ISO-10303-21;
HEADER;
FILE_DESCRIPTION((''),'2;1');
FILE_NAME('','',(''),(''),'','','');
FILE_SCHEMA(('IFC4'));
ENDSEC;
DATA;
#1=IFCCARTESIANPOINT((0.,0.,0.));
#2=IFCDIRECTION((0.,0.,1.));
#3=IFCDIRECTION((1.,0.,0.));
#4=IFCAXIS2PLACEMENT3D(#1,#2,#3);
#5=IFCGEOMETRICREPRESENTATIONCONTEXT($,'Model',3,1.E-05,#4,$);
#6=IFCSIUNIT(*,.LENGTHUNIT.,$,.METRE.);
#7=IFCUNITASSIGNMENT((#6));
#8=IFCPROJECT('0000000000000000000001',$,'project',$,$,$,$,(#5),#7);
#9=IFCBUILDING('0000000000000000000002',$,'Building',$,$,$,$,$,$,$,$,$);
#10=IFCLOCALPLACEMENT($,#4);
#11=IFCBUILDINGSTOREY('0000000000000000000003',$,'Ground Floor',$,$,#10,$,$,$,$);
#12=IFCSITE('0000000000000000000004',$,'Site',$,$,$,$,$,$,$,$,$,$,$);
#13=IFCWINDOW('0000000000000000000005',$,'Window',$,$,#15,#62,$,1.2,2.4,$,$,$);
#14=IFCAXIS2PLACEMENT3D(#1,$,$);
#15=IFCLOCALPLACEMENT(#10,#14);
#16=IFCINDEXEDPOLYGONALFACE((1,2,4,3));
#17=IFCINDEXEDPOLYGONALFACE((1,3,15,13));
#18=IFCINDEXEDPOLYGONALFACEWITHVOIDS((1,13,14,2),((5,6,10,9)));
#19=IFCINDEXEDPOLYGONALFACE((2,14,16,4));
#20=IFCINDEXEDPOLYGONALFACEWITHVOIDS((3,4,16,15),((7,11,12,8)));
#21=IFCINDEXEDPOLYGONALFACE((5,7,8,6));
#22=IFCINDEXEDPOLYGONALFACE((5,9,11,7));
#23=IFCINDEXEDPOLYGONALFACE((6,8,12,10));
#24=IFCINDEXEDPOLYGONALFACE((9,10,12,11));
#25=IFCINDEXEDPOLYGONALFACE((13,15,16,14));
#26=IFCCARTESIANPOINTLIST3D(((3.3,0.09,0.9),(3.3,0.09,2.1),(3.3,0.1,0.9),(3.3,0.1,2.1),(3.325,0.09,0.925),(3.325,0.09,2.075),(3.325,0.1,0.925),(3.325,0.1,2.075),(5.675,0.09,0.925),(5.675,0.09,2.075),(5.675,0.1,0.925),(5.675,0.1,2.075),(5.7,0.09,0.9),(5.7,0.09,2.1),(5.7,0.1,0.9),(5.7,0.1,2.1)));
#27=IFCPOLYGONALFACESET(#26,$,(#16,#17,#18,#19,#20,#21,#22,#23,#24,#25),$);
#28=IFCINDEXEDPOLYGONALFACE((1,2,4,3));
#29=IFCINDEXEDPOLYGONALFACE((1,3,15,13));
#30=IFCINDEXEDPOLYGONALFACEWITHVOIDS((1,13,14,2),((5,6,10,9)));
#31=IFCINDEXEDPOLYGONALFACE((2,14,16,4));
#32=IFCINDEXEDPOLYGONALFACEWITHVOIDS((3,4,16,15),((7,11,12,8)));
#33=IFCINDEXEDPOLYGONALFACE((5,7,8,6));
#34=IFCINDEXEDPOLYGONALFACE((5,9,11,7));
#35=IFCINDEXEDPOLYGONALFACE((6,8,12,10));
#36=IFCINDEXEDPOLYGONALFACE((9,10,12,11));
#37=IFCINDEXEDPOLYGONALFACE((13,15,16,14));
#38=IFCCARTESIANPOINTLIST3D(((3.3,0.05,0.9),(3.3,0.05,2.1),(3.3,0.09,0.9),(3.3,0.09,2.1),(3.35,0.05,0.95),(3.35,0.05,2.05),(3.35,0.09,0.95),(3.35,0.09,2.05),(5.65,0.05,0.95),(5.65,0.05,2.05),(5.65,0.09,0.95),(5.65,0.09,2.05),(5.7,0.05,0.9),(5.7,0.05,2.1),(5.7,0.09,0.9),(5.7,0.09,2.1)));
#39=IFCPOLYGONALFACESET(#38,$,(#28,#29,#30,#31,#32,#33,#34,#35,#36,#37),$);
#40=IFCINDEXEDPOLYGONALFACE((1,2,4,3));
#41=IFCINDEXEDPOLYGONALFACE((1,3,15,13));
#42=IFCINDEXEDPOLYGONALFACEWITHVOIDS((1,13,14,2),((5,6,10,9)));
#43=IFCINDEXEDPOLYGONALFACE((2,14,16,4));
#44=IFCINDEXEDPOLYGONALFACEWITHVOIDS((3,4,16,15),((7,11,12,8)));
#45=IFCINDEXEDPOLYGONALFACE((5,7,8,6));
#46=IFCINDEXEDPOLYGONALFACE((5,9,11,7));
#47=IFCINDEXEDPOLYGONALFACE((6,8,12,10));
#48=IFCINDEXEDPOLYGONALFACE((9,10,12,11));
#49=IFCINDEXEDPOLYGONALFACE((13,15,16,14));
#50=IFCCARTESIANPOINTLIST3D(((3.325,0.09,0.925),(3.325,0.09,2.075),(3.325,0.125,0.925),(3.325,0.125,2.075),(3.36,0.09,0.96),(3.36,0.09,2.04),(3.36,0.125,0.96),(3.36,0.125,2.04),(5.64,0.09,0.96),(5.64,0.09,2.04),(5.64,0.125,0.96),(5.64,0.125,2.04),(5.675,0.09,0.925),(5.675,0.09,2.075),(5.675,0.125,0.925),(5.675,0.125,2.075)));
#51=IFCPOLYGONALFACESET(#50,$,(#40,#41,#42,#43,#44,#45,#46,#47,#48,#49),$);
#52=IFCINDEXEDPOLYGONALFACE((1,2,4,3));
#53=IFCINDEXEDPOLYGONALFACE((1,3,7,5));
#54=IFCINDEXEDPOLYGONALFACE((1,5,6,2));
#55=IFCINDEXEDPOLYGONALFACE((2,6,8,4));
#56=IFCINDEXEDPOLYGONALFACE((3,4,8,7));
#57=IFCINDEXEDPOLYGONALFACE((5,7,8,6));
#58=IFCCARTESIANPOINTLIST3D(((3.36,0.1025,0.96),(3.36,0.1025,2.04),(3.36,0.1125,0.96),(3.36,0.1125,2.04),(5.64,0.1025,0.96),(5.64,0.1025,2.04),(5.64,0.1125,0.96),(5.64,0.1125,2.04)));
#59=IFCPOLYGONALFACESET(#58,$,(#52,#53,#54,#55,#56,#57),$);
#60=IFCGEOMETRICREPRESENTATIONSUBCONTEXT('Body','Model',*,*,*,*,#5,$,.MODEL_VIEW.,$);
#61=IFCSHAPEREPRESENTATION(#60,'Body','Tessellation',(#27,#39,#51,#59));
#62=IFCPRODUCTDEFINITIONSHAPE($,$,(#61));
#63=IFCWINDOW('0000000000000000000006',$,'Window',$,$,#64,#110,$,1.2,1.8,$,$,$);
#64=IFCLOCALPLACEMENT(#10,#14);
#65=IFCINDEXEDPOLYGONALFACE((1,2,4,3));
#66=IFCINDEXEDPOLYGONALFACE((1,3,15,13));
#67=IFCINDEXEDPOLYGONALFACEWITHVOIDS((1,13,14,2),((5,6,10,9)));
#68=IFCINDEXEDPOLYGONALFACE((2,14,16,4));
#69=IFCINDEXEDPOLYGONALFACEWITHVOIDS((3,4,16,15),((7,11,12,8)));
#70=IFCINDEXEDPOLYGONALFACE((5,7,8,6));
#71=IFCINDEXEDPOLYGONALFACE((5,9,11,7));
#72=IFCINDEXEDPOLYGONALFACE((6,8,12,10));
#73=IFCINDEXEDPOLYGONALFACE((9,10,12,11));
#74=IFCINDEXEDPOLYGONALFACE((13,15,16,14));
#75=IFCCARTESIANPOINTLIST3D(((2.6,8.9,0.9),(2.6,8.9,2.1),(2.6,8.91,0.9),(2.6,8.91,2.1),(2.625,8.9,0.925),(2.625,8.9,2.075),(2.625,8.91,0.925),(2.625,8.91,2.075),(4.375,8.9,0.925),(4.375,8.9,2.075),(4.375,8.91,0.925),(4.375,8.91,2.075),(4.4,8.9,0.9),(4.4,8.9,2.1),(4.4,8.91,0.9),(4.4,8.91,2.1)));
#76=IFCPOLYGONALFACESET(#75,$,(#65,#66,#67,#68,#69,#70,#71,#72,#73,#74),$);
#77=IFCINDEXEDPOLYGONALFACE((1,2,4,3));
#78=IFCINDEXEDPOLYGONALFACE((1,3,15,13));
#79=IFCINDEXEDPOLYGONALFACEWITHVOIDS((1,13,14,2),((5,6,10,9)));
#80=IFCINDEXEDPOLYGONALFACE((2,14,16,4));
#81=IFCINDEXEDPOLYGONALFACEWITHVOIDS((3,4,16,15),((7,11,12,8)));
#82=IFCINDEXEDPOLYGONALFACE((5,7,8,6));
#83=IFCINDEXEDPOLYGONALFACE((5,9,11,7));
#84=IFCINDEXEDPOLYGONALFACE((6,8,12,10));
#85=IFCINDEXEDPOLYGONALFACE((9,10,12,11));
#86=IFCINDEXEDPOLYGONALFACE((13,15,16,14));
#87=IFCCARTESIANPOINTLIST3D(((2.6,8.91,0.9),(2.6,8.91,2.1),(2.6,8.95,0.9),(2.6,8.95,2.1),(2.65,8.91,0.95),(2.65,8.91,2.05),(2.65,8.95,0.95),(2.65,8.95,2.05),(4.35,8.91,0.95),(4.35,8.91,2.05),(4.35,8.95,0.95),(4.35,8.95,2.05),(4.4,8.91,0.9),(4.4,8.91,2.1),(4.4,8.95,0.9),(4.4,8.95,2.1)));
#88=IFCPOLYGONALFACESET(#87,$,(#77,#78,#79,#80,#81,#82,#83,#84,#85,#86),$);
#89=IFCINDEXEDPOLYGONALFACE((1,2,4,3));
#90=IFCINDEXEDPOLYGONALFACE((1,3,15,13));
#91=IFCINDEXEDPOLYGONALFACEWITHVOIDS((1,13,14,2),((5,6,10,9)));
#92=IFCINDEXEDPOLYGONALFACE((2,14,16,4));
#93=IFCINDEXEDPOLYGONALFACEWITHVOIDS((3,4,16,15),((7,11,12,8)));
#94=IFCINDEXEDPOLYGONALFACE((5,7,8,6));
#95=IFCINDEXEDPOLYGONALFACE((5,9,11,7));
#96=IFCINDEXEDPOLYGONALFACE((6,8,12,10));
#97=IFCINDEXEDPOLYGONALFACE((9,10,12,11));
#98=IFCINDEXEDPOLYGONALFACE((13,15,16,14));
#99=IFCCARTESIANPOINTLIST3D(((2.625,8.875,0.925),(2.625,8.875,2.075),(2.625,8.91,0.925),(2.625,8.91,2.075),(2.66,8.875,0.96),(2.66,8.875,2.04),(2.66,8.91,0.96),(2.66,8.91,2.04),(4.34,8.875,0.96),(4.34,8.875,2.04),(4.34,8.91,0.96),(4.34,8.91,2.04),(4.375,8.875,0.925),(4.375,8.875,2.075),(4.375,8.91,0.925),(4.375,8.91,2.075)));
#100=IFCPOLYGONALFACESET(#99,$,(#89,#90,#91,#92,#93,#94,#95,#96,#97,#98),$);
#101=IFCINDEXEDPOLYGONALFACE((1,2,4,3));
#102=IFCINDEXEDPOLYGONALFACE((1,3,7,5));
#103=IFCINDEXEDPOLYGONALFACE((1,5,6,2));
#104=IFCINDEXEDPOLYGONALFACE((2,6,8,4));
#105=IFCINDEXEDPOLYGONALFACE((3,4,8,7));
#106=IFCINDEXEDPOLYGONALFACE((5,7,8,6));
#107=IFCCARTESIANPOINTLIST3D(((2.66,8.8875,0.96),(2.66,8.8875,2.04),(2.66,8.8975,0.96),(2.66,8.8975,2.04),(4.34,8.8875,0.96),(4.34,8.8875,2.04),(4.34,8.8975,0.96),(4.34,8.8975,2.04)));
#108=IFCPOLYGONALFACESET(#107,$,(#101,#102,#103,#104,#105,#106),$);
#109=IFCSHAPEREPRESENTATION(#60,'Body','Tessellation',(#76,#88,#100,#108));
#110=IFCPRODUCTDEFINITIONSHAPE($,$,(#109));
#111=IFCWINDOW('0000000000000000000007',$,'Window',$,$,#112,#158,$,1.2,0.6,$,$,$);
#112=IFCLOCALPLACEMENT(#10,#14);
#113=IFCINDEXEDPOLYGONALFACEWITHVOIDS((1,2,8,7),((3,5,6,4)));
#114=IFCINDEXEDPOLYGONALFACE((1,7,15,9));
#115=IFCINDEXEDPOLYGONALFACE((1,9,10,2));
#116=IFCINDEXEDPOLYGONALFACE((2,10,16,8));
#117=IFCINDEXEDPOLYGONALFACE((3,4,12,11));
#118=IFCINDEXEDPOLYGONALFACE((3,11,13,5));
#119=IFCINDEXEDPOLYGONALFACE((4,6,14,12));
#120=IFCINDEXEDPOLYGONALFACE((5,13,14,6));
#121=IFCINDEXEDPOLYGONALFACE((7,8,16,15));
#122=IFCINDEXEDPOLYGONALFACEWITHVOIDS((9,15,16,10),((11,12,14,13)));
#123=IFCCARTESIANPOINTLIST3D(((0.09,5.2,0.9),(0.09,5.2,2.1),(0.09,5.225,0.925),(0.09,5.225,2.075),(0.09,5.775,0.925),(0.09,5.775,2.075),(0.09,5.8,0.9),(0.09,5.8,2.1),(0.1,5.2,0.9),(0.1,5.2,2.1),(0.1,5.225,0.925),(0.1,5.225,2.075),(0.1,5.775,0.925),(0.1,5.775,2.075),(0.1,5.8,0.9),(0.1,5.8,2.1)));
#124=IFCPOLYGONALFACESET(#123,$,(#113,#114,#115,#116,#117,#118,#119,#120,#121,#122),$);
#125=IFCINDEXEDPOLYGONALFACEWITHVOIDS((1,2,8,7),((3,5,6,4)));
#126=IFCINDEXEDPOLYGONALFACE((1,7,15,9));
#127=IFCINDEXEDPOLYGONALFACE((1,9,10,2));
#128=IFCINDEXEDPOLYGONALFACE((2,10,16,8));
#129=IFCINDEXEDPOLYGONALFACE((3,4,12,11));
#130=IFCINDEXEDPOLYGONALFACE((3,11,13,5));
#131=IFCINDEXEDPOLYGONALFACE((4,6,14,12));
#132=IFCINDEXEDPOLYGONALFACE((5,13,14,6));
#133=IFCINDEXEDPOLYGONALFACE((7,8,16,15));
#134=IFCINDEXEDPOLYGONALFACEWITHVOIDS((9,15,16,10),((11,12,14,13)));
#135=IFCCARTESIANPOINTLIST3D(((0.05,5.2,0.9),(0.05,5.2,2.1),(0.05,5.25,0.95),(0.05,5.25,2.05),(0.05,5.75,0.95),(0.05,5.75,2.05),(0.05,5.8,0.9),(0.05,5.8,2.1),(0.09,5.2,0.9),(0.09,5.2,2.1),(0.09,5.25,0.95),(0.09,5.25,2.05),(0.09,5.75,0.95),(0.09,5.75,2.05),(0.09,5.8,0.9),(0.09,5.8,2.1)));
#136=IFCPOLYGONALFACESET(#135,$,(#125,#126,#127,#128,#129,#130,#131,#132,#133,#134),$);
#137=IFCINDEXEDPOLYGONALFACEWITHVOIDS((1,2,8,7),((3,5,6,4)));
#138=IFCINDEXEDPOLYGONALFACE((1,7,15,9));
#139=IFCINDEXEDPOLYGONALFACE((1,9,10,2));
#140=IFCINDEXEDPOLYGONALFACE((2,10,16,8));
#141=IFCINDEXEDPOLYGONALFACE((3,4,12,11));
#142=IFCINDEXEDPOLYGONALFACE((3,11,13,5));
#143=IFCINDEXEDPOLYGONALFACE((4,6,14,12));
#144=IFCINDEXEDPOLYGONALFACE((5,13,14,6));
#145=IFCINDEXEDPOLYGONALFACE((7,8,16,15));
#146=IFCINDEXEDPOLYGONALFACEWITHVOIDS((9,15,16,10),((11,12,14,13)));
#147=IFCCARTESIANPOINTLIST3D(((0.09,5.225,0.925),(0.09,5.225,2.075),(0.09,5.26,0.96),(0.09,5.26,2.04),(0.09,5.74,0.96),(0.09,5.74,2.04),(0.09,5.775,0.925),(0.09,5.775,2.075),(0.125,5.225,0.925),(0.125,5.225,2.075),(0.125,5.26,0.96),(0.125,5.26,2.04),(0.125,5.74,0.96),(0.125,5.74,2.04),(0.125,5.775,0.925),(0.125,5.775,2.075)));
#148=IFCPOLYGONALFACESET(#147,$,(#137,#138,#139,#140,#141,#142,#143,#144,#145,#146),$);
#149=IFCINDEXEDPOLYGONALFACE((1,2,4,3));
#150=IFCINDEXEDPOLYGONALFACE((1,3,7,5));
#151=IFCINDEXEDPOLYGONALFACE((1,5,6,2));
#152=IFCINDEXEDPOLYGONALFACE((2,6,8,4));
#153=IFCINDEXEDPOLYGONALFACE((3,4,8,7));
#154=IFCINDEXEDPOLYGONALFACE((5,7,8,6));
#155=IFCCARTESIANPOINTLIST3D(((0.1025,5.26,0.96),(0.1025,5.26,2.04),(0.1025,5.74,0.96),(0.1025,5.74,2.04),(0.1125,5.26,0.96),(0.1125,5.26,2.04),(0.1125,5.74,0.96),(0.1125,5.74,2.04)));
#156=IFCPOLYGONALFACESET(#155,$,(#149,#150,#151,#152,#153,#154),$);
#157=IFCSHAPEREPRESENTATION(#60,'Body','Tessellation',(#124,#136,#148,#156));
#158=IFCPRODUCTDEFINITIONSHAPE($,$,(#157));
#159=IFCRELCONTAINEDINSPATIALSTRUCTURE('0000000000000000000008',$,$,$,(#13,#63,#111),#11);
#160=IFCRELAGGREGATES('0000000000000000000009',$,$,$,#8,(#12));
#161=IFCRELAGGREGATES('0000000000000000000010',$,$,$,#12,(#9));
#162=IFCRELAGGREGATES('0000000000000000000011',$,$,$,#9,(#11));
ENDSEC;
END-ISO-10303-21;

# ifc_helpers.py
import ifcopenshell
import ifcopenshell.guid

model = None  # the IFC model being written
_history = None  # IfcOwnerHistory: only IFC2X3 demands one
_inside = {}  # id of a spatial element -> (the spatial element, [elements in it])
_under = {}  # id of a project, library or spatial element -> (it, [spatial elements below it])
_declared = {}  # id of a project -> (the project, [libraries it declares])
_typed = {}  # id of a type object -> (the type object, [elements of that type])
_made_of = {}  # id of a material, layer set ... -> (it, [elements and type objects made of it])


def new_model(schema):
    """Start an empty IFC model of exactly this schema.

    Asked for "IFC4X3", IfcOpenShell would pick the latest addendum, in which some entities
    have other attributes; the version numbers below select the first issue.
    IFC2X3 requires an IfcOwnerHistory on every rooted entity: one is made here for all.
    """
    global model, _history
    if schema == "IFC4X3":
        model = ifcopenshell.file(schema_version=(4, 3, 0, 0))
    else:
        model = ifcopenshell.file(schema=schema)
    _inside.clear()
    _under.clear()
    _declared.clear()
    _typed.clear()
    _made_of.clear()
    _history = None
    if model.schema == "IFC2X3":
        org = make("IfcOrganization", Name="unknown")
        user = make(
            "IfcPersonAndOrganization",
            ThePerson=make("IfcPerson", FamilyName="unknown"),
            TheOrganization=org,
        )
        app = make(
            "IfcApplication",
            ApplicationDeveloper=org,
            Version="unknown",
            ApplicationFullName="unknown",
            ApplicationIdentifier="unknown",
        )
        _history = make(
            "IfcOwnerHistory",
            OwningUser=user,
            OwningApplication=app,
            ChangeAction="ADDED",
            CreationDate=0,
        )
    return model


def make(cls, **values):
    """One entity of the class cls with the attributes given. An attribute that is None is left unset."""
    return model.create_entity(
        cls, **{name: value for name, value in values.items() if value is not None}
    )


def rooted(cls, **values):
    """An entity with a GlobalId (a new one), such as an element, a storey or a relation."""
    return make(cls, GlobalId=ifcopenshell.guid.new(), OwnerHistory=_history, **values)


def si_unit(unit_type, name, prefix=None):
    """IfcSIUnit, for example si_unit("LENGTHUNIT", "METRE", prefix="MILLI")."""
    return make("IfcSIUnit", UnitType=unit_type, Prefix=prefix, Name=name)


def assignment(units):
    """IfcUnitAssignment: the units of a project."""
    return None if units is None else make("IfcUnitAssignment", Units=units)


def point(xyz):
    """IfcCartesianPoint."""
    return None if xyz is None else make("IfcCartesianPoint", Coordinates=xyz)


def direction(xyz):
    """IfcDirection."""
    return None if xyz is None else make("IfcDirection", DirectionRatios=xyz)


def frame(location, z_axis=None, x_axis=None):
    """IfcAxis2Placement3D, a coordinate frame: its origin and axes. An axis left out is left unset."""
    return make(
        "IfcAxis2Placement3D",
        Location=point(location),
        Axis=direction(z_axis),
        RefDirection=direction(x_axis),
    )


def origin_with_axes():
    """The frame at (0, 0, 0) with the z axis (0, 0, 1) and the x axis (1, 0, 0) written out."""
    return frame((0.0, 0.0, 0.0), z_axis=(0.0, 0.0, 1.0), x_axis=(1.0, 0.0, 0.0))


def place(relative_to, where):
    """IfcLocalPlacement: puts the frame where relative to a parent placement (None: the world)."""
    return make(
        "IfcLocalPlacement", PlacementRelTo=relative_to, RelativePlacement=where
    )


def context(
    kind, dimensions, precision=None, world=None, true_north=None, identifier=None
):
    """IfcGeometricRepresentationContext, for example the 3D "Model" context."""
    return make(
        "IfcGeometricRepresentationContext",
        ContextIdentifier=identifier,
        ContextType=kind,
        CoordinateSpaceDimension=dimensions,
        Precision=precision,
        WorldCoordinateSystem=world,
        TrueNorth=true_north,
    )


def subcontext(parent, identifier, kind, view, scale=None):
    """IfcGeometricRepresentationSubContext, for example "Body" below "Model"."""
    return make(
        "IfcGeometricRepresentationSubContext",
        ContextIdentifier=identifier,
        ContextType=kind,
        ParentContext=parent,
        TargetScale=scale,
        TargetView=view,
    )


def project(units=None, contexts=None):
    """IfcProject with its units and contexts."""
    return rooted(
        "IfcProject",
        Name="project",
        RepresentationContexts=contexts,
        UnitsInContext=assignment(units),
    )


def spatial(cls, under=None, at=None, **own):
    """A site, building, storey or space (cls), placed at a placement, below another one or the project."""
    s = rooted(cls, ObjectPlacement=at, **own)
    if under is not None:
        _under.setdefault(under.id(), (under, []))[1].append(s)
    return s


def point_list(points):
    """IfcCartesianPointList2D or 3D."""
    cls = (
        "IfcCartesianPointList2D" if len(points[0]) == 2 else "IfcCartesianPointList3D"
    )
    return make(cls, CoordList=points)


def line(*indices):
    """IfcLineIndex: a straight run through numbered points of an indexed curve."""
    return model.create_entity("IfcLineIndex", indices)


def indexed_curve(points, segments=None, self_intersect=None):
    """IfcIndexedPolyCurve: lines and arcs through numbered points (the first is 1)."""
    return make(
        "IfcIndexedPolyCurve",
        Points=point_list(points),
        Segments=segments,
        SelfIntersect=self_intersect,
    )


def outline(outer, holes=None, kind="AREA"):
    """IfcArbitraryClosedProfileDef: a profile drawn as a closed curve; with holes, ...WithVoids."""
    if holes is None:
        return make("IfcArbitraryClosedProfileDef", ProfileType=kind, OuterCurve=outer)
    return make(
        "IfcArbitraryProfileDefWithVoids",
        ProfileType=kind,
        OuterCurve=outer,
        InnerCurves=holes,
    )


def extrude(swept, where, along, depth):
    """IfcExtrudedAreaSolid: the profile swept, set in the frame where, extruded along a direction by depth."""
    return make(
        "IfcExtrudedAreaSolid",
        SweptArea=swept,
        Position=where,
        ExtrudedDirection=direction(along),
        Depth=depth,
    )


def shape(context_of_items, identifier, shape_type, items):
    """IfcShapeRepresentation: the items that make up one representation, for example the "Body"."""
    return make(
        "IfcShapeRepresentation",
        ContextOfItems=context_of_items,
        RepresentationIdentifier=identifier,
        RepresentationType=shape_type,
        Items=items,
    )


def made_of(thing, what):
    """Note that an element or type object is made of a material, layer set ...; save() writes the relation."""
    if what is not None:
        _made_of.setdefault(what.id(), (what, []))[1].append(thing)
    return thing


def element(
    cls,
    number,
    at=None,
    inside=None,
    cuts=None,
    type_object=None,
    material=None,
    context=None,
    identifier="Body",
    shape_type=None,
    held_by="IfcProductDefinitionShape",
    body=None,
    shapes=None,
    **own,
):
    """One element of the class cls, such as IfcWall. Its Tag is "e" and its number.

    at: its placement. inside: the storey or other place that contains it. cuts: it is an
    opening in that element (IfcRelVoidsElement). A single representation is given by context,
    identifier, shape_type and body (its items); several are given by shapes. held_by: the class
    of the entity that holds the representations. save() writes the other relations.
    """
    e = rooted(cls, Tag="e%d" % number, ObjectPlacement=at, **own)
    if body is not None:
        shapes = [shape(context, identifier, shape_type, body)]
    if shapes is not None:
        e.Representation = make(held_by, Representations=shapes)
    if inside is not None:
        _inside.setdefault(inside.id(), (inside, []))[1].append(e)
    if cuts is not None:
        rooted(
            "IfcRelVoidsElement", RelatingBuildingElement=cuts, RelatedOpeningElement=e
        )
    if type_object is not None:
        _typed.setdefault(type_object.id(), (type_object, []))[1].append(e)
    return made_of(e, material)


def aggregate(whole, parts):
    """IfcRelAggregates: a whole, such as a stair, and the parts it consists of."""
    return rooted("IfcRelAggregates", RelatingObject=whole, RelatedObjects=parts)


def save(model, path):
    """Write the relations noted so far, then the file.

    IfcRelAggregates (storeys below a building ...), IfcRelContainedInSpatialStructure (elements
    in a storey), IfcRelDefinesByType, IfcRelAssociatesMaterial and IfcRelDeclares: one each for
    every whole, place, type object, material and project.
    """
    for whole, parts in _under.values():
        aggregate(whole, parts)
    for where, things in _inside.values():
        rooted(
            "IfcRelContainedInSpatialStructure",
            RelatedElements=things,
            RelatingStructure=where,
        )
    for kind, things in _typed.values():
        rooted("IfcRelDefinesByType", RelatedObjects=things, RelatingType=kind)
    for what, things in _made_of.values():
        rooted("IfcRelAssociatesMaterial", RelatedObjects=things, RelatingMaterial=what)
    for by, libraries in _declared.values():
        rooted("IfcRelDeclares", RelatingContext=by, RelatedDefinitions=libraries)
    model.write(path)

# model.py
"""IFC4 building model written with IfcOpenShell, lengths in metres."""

from ifc_helpers import new_model, si_unit, frame, origin_with_axes, place, context, subcontext, project, spatial, line, indexed_curve, outline, extrude, element, save


model = new_model("IFC4")

# Units and contexts
model_context = context("Model", 3, precision=1e-05, world=origin_with_axes())
body_context = subcontext(model_context, "Body", "Model", "MODEL_VIEW")
ifc_project = project(units=[si_unit("LENGTHUNIT", "METRE")], contexts=[model_context])

# Site, building, storey
site = spatial("IfcSite", under=ifc_project, Name="Site")
building = spatial("IfcBuilding", under=site, Name="Building")
storey_placement = place(None, origin_with_axes())
storey = spatial("IfcBuildingStorey", under=building, at=storey_placement, Name="Ground Floor")

# Windows
window_1_placement = place(storey_placement, frame((3.3, 0.0, 0.9), z_axis=(0.0, 0.0, 1.0), x_axis=(1.0, 0.0, 0.0)))
element("IfcWindow", 1, at=window_1_placement, inside=storey, Name="Window", OverallHeight=1.2, OverallWidth=2.4, context=body_context, shape_type="SweptSolid", body=[
    extrude(outline(indexed_curve([(0.0, 0.0), (2.4, 0.0), (2.4, 1.2), (0.0, 1.2)], segments=[line(1, 2, 3, 4, 1)]), holes=[indexed_curve([(0.025, 0.025), (2.375, 0.025), (2.375, 1.175), (0.025, 1.175)], segments=[line(1, 2, 3, 4, 1)])]), frame((0.0, 0.09, 0.0), z_axis=(0.0, -1.0, 0.0), x_axis=(1.0, 0.0, 0.0)), (0.0, 0.0, -1.0), 0.01),
    extrude(outline(indexed_curve([(0.0, 0.0), (2.4, 0.0), (2.4, 1.2), (0.0, 1.2)], segments=[line(1, 2, 3, 4, 1)]), holes=[indexed_curve([(0.05, 0.05), (2.35, 0.05), (2.35, 1.15), (0.05, 1.15)], segments=[line(1, 2, 3, 4, 1)])]), frame((0.0, 0.05, 0.0), z_axis=(0.0, -1.0, 0.0), x_axis=(1.0, 0.0, 0.0)), (0.0, 0.0, -1.0), 0.04),
    extrude(outline(indexed_curve([(0.0, 0.0), (2.35, 0.0), (2.35, 1.15), (0.0, 1.15)], segments=[line(1, 2, 3, 4, 1)]), holes=[indexed_curve([(0.035, 0.035), (2.315, 0.035), (2.315, 1.115), (0.035, 1.115)], segments=[line(1, 2, 3, 4, 1)])]), frame((0.025, 0.09, 0.025), z_axis=(0.0, -1.0, 0.0), x_axis=(1.0, 0.0, 0.0)), (0.0, 0.0, -1.0), 0.035),
    extrude(outline(indexed_curve([(0.035, 0.035), (2.315, 0.035), (2.315, 1.115), (0.035, 1.115)], segments=[line(1, 2, 3, 4, 1)])), frame((0.025, 0.1025, 0.025), z_axis=(0.0, -1.0, 0.0), x_axis=(1.0, 0.0, 0.0)), (0.0, 0.0, -1.0), 0.01),
])
window_2_placement = place(storey_placement, frame((4.4, 9.0, 0.9), z_axis=(0.0, 0.0, 1.0), x_axis=(-1.0, 0.0, 0.0)))
element("IfcWindow", 2, at=window_2_placement, inside=storey, Name="Window", OverallHeight=1.2, OverallWidth=1.8, context=body_context, shape_type="SweptSolid", body=[
    extrude(outline(indexed_curve([(0.0, 0.0), (1.8, 0.0), (1.8, 1.2), (0.0, 1.2)], segments=[line(1, 2, 3, 4, 1)]), holes=[indexed_curve([(0.025, 0.025), (1.775, 0.025), (1.775, 1.175), (0.025, 1.175)], segments=[line(1, 2, 3, 4, 1)])]), frame((0.0, 0.09, 0.0), z_axis=(0.0, -1.0, 0.0), x_axis=(1.0, 0.0, 0.0)), (0.0, 0.0, -1.0), 0.01),
    extrude(outline(indexed_curve([(0.0, 0.0), (1.8, 0.0), (1.8, 1.2), (0.0, 1.2)], segments=[line(1, 2, 3, 4, 1)]), holes=[indexed_curve([(0.05, 0.05), (1.75, 0.05), (1.75, 1.15), (0.05, 1.15)], segments=[line(1, 2, 3, 4, 1)])]), frame((0.0, 0.05, 0.0), z_axis=(0.0, -1.0, 0.0), x_axis=(1.0, 0.0, 0.0)), (0.0, 0.0, -1.0), 0.04),
    extrude(outline(indexed_curve([(0.0, 0.0), (1.75, 0.0), (1.75, 1.15), (0.0, 1.15)], segments=[line(1, 2, 3, 4, 1)]), holes=[indexed_curve([(0.035, 0.035), (1.715, 0.035), (1.715, 1.115), (0.035, 1.115)], segments=[line(1, 2, 3, 4, 1)])]), frame((0.025, 0.09, 0.025), z_axis=(0.0, -1.0, 0.0), x_axis=(1.0, 0.0, 0.0)), (0.0, 0.0, -1.0), 0.035),
    extrude(outline(indexed_curve([(0.035, 0.035), (1.715, 0.035), (1.715, 1.115), (0.035, 1.115)], segments=[line(1, 2, 3, 4, 1)])), frame((0.025, 0.1025, 0.025), z_axis=(0.0, -1.0, 0.0), x_axis=(1.0, 0.0, 0.0)), (0.0, 0.0, -1.0), 0.01),
])
window_3_placement = place(storey_placement, frame((0.0, 5.8, 0.9), z_axis=(0.0, 0.0, 1.0), x_axis=(0.0, -1.0, 0.0)))
element("IfcWindow", 3, at=window_3_placement, inside=storey, Name="Window", OverallHeight=1.2, OverallWidth=0.6, context=body_context, shape_type="SweptSolid", body=[
    extrude(outline(indexed_curve([(0.0, 0.0), (0.6, 0.0), (0.6, 1.2), (0.0, 1.2)], segments=[line(1, 2, 3, 4, 1)]), holes=[indexed_curve([(0.025, 0.025), (0.575, 0.025), (0.575, 1.175), (0.025, 1.175)], segments=[line(1, 2, 3, 4, 1)])]), frame((0.0, 0.09, 0.0), z_axis=(0.0, -1.0, 0.0), x_axis=(1.0, 0.0, 0.0)), (0.0, 0.0, -1.0), 0.01),
    extrude(outline(indexed_curve([(0.0, 0.0), (0.6, 0.0), (0.6, 1.2), (0.0, 1.2)], segments=[line(1, 2, 3, 4, 1)]), holes=[indexed_curve([(0.05, 0.05), (0.55, 0.05), (0.55, 1.15), (0.05, 1.15)], segments=[line(1, 2, 3, 4, 1)])]), frame((0.0, 0.05, 0.0), z_axis=(0.0, -1.0, 0.0), x_axis=(1.0, 0.0, 0.0)), (0.0, 0.0, -1.0), 0.04),
    extrude(outline(indexed_curve([(0.0, 0.0), (0.55, 0.0), (0.55, 1.15), (0.0, 1.15)], segments=[line(1, 2, 3, 4, 1)]), holes=[indexed_curve([(0.035, 0.035), (0.515, 0.035), (0.515, 1.115), (0.035, 1.115)], segments=[line(1, 2, 3, 4, 1)])]), frame((0.025, 0.09, 0.025), z_axis=(0.0, -1.0, 0.0), x_axis=(1.0, 0.0, 0.0)), (0.0, 0.0, -1.0), 0.035),
    extrude(outline(indexed_curve([(0.035, 0.035), (0.515, 0.035), (0.515, 1.115), (0.035, 1.115)], segments=[line(1, 2, 3, 4, 1)])), frame((0.025, 0.1025, 0.025), z_axis=(0.0, -1.0, 0.0), x_axis=(1.0, 0.0, 0.0)), (0.0, 0.0, -1.0), 0.01),
])

save(model, "model.ifc")
